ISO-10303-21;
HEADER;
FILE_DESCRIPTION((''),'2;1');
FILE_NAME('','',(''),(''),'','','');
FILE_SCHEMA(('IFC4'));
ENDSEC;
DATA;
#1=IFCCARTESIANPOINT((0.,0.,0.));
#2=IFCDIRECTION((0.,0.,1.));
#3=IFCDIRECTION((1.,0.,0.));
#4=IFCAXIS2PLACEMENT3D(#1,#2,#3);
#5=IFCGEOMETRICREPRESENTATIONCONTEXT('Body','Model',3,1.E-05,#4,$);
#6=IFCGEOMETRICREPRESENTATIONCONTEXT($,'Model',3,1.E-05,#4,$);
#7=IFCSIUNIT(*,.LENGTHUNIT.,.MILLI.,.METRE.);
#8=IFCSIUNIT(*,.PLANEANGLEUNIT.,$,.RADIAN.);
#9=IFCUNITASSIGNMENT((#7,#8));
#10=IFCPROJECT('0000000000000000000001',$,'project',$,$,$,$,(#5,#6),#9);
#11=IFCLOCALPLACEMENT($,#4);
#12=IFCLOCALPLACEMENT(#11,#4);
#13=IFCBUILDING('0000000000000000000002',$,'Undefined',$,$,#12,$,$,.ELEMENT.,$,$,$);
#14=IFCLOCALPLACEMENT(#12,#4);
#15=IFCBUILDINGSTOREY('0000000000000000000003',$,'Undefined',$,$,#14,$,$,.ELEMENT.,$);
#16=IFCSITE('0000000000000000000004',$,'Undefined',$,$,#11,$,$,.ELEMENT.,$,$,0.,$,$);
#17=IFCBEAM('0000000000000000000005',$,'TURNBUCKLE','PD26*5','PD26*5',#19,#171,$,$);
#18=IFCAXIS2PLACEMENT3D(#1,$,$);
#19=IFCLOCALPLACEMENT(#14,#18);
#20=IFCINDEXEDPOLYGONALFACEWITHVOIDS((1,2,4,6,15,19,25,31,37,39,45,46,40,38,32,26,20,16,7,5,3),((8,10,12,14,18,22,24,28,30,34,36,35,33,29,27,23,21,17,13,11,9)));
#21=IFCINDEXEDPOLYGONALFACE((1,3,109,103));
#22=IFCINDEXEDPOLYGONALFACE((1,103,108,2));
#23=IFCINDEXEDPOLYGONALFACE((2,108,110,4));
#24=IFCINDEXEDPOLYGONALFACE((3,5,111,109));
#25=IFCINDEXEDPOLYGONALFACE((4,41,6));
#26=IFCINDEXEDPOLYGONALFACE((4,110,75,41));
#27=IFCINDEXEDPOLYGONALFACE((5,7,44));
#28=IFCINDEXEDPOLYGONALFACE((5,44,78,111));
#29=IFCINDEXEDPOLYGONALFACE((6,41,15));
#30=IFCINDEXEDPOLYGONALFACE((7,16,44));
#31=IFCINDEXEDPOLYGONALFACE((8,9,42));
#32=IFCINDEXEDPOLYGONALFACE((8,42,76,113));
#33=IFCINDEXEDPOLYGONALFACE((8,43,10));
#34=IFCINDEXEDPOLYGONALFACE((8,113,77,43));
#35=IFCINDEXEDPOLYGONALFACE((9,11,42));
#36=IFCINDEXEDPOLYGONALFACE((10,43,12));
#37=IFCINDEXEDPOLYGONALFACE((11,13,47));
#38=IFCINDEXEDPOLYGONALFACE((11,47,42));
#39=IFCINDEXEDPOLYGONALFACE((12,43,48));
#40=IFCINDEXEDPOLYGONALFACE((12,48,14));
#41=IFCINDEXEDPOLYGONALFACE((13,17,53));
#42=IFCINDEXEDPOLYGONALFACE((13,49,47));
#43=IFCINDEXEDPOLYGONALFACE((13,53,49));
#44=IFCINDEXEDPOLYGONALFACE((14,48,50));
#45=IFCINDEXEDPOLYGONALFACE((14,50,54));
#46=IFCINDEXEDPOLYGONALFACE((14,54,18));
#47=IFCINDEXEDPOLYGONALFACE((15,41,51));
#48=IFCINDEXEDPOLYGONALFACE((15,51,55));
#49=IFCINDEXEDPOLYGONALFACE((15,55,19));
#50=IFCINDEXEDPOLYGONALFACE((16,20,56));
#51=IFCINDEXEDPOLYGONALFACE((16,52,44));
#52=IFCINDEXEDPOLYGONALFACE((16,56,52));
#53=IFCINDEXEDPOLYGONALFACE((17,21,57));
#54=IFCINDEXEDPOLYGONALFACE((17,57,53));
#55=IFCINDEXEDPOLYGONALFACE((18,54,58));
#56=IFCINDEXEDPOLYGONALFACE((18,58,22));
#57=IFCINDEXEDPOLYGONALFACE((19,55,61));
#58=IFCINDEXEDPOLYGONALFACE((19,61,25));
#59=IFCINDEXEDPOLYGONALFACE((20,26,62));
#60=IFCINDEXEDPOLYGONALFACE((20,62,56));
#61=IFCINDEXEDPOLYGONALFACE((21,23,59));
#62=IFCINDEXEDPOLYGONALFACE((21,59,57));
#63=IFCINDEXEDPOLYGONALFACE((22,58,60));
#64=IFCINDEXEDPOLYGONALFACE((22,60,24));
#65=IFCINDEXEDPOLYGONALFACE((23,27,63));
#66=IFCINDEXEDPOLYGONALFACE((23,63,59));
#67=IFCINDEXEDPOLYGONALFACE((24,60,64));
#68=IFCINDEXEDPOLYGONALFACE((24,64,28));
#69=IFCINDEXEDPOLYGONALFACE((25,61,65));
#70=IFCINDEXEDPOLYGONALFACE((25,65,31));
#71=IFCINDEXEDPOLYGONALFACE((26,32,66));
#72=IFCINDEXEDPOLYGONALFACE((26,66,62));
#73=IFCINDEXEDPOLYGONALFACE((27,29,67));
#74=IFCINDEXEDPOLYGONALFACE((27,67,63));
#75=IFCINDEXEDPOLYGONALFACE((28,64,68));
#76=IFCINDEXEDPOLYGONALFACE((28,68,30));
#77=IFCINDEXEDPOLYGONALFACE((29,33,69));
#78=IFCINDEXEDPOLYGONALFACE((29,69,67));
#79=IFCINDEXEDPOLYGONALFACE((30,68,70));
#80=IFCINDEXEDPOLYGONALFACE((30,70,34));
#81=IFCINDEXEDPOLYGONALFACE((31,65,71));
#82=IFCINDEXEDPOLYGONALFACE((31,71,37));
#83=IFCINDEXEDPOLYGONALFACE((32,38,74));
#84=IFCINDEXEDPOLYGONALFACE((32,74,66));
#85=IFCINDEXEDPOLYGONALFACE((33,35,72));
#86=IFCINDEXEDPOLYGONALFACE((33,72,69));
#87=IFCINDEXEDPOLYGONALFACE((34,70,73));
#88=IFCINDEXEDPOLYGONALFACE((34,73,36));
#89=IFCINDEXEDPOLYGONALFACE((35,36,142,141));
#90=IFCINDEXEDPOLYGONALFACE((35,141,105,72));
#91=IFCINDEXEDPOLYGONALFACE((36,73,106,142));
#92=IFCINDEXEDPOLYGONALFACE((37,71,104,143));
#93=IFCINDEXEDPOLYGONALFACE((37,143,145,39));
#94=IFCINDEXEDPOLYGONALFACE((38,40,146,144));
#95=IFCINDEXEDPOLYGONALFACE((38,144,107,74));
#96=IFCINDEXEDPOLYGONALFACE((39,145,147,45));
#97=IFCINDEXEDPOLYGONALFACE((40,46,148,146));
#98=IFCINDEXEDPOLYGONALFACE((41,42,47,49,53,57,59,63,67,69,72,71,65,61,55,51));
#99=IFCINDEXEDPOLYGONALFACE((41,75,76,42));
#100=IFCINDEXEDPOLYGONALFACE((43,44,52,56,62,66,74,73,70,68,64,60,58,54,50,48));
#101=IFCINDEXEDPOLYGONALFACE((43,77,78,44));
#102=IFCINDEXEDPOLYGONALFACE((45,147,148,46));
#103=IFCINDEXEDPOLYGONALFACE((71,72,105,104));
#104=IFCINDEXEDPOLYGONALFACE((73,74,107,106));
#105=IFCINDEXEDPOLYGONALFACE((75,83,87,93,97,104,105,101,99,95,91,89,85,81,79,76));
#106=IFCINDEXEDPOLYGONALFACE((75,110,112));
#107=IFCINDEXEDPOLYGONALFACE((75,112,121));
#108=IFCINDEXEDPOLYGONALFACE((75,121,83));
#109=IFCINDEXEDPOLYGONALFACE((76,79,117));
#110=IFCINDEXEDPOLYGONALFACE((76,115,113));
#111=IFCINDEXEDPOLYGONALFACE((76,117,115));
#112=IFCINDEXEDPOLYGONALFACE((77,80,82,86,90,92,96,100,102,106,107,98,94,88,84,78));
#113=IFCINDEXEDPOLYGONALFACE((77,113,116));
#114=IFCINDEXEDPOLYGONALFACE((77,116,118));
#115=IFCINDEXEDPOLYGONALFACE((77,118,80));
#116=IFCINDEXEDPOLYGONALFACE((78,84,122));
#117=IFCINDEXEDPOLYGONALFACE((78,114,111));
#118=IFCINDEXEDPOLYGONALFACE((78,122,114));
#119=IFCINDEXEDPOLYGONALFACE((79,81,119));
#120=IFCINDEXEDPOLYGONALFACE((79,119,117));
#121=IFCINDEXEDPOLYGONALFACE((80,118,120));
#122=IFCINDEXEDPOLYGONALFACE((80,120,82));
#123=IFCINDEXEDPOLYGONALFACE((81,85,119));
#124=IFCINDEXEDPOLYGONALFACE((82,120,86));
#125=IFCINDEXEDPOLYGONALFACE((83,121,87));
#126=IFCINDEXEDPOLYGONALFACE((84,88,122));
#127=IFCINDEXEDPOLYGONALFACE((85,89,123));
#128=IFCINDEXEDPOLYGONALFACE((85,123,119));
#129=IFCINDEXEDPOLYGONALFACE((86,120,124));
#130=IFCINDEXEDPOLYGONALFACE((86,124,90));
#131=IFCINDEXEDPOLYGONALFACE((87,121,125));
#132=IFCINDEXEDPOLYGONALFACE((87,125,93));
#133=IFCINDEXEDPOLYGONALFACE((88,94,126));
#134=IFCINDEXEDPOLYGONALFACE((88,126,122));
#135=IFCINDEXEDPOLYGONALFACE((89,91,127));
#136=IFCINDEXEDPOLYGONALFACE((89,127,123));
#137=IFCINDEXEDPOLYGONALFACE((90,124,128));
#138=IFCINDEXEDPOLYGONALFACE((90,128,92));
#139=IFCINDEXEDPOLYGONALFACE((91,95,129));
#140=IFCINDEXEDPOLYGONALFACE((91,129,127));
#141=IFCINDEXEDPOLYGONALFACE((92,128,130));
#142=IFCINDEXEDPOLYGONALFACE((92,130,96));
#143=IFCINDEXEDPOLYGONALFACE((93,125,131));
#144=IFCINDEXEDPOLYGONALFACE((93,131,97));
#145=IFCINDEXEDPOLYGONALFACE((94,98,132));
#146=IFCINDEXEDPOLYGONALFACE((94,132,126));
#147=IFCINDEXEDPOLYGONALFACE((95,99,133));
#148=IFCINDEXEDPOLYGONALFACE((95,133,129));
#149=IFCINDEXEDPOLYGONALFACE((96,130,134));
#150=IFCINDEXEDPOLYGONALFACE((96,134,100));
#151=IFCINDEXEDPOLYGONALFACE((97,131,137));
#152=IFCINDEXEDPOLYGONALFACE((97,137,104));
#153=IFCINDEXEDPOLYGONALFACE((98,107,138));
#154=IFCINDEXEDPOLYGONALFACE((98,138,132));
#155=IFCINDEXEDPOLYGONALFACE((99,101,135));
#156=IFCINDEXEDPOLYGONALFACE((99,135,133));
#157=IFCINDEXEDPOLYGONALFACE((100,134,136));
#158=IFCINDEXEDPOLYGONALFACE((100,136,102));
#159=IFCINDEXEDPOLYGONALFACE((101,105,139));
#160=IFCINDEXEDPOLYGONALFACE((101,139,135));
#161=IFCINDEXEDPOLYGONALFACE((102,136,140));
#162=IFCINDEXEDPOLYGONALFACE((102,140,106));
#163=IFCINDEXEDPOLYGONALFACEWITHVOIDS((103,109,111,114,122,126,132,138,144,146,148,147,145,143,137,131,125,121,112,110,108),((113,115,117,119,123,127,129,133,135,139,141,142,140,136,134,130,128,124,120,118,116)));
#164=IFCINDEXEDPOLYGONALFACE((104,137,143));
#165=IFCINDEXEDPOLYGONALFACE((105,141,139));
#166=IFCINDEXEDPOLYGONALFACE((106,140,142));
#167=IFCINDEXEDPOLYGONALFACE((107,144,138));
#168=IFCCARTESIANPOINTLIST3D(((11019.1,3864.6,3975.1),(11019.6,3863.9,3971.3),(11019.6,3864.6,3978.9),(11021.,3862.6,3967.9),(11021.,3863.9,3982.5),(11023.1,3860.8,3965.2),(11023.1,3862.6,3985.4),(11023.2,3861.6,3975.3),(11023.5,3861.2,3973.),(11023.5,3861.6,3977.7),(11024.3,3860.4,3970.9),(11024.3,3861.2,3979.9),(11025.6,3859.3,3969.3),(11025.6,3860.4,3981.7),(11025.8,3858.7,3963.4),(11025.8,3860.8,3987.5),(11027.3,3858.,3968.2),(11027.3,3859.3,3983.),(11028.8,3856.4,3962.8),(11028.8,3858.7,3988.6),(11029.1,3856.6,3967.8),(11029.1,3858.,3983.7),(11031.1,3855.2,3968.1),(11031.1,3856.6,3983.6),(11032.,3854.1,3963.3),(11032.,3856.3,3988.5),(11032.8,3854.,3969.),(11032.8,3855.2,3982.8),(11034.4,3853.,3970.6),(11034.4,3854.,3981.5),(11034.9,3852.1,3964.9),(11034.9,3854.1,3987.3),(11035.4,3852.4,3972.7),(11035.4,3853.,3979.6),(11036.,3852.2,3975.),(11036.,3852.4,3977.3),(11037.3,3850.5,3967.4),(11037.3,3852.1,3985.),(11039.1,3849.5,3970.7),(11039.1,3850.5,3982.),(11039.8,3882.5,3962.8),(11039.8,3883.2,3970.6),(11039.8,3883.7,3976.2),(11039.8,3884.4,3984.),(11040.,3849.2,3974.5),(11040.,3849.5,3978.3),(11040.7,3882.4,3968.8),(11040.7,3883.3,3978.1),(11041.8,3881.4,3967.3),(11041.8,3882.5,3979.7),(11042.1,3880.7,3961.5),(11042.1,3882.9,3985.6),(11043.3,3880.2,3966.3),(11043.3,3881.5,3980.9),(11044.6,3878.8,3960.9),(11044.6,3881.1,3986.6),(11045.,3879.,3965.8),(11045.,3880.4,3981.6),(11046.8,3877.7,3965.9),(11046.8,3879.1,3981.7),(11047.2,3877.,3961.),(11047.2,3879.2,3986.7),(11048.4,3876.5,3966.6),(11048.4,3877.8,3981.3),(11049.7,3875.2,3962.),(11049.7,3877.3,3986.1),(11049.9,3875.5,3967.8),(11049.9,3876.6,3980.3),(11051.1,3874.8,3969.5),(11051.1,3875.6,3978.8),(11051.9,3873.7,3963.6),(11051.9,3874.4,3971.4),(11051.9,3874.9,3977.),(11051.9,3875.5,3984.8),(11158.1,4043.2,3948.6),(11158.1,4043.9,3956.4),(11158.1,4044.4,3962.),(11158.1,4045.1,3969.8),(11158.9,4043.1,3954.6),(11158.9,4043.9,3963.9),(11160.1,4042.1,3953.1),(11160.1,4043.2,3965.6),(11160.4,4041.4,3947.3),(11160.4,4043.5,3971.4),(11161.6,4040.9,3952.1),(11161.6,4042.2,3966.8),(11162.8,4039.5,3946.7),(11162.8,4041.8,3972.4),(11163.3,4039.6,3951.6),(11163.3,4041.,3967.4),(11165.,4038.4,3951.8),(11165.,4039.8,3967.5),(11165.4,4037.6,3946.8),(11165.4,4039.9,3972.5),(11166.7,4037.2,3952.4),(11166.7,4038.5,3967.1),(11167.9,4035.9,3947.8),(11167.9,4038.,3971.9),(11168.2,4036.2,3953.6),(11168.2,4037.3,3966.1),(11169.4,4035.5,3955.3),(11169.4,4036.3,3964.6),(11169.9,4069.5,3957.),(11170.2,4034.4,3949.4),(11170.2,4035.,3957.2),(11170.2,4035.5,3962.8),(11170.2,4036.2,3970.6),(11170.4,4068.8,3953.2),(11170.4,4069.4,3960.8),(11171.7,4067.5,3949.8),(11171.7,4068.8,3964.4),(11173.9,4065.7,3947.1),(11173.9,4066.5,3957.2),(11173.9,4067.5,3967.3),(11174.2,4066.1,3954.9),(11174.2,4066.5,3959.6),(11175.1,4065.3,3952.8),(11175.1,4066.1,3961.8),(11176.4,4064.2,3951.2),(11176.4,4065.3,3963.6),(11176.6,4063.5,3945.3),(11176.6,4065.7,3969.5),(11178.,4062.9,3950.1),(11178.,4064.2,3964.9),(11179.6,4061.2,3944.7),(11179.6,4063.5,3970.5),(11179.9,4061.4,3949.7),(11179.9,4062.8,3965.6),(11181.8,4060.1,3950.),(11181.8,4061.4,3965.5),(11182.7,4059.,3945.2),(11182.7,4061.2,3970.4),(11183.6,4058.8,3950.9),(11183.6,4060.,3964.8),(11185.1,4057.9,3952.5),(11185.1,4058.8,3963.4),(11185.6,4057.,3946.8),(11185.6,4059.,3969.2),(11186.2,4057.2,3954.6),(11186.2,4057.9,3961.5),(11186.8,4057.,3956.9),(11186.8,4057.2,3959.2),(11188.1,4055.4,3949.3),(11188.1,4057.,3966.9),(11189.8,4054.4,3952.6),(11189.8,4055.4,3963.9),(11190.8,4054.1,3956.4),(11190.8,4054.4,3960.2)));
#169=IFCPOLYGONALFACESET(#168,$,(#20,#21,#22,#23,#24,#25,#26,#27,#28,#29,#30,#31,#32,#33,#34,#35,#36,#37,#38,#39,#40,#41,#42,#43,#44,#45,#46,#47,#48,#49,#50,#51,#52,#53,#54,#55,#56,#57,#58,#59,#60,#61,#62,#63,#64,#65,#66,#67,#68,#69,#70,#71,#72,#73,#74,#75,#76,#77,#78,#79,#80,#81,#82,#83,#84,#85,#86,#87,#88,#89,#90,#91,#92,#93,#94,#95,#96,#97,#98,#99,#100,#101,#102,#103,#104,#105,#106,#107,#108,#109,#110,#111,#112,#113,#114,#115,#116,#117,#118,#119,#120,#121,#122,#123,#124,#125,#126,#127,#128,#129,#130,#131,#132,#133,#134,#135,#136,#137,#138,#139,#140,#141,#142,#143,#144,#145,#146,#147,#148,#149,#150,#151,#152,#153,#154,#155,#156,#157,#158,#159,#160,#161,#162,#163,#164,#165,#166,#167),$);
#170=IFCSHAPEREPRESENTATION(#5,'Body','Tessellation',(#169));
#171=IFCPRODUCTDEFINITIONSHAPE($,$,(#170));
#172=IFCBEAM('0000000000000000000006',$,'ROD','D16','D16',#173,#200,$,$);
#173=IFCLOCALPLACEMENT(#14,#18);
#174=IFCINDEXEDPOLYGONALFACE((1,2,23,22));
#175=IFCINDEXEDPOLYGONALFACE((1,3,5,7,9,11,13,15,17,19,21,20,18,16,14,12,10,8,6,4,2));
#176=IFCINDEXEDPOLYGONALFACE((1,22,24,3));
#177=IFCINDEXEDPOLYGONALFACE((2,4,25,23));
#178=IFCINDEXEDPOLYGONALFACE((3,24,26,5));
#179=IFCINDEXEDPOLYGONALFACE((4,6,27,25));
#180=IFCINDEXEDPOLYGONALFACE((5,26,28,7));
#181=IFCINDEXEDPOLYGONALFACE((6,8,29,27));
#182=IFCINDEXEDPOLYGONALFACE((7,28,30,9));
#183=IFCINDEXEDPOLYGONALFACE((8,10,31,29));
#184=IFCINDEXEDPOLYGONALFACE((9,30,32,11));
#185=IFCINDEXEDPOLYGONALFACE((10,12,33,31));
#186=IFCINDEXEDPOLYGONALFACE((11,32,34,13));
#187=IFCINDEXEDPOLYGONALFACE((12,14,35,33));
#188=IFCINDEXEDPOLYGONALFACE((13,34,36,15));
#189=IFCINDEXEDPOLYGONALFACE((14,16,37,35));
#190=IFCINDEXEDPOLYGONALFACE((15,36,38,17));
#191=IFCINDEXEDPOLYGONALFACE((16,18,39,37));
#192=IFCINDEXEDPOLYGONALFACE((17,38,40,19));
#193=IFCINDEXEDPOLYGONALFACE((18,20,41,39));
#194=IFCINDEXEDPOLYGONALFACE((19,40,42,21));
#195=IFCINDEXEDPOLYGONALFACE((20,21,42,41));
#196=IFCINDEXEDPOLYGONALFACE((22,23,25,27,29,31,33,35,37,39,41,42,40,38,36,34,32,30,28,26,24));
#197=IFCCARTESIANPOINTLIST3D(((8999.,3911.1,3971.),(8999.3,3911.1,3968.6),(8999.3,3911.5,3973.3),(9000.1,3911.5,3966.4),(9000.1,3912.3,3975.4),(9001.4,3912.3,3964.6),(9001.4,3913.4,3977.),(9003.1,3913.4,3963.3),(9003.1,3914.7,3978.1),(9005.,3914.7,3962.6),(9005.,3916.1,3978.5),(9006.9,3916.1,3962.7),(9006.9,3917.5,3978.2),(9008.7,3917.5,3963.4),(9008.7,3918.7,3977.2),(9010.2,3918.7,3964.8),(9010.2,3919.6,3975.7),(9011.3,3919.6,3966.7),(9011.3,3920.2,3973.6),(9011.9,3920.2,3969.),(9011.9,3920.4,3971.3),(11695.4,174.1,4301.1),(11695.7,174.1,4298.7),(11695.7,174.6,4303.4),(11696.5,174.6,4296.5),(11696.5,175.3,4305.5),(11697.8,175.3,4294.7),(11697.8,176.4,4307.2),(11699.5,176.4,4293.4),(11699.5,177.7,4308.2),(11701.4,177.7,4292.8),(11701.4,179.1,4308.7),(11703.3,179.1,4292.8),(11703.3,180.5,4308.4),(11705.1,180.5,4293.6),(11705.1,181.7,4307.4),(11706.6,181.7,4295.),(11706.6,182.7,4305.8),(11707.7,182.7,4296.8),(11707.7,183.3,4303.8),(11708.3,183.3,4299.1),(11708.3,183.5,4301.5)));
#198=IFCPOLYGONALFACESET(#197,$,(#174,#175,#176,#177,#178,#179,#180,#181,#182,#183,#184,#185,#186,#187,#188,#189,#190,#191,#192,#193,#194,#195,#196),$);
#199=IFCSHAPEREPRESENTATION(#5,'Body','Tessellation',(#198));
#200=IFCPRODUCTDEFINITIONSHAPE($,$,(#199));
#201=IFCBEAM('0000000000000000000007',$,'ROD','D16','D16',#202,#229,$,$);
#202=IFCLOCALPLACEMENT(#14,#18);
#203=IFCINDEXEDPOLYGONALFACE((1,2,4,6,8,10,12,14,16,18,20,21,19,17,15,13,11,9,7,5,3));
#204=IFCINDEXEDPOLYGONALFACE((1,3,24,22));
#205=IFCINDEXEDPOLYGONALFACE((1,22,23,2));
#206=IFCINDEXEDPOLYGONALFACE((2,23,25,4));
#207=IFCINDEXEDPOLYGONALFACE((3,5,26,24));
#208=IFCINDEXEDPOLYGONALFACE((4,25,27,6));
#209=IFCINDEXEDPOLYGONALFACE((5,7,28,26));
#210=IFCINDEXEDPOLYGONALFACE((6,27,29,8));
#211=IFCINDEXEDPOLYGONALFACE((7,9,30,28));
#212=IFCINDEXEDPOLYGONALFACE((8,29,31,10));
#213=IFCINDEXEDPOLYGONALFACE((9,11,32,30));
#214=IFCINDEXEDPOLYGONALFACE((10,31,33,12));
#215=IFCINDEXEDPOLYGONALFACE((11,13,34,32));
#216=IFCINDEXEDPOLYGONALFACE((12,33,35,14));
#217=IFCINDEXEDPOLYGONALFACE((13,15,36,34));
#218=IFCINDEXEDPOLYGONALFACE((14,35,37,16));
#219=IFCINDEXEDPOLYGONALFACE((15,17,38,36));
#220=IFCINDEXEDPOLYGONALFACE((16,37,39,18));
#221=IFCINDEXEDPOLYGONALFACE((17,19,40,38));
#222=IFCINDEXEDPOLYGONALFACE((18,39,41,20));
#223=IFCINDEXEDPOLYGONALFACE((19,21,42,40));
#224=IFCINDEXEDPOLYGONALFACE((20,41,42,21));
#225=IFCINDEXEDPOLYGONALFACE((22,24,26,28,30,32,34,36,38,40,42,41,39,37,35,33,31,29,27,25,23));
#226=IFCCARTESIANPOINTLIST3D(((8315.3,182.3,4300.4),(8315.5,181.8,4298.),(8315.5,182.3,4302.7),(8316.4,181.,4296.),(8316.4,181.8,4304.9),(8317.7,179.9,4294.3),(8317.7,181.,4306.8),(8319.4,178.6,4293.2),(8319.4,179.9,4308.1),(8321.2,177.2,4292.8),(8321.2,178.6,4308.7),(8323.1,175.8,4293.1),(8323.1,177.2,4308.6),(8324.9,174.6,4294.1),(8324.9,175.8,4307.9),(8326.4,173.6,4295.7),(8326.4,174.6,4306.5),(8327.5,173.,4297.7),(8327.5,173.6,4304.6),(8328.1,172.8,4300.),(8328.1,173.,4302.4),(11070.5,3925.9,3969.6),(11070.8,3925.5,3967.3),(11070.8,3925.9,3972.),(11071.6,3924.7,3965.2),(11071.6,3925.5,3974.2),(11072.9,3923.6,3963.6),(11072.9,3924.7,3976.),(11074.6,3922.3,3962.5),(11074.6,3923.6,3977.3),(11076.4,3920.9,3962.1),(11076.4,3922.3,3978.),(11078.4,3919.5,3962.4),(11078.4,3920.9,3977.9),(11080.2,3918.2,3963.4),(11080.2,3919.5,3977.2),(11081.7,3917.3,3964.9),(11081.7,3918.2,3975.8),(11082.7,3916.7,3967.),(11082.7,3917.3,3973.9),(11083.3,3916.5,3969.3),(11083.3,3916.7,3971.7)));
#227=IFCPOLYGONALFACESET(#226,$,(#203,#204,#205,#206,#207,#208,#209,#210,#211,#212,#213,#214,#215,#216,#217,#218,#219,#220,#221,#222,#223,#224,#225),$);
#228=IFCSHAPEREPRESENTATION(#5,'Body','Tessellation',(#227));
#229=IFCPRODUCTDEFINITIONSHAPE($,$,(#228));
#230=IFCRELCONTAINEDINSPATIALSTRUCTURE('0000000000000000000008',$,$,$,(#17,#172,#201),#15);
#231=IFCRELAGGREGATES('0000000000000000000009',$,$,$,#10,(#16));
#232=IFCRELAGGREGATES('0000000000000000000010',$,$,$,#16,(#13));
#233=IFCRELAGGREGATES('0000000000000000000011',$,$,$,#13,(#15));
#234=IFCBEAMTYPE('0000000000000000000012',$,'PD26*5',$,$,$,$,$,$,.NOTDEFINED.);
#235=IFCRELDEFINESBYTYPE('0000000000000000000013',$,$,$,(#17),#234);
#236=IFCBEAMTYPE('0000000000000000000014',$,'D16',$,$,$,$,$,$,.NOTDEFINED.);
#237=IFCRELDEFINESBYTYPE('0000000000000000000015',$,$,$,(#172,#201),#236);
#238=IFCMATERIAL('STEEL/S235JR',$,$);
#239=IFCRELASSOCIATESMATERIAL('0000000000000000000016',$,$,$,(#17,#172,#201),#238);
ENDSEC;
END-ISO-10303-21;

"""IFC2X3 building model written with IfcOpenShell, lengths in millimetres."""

from ifc_helpers import new_model, si_unit, frame, origin_with_axes, origin_2d_with_axis, place, context, project, spatial, rectangle, circle, hollow_circle, extrude, material, type_object, element, save


model = new_model("IFC2X3")

# Units and contexts
model_context_1 = context("Model", 3, precision=1e-05, world=origin_with_axes(), identifier="Body")
model_context_2 = context("Model", 3, precision=1e-05, world=origin_with_axes())
ifc_project = project(units=[si_unit("LENGTHUNIT", "METRE", prefix="MILLI"), si_unit("PLANEANGLEUNIT", "RADIAN")], contexts=[model_context_1, model_context_2])

# Site, building, storey
site_placement = place(None, origin_with_axes())
site = spatial("IfcSite", under=ifc_project, at=site_placement, Name="Undefined", CompositionType="ELEMENT", RefElevation=0.0)
building_placement = place(site_placement, origin_with_axes())
building = spatial("IfcBuilding", under=site, at=building_placement, Name="Undefined", CompositionType="ELEMENT")
storey_placement = place(building_placement, origin_with_axes())
storey = spatial("IfcBuildingStorey", under=building, at=storey_placement, Name="Undefined", CompositionType="ELEMENT")

# Shared definitions
ifc_material = material(Name="STEEL/S235JR")

# Beam, opening
beam_type_1 = type_object("IfcBeamType", Name="PD26*5", PredefinedType="NOTDEFINED")
beam_1_placement = place(storey_placement, frame((11180.4, 4061.8, 3957.6), z_axis=(0.0, 0.087999, 0.996121), x_axis=(-0.591248, -0.803361, 0.070971)))
beam_1 = element("IfcBeam", 1, at=beam_1_placement, inside=storey, type_object=beam_type_1, material=ifc_material, Name="TURNBUCKLE", Description="PD26*5", ObjectType="PD26*5", context=model_context_1, shape_type="SweptSolid", body=[
    extrude(hollow_circle(Radius=13.0, WallThickness=5.0, at=origin_2d_with_axis()), frame((255.0, 0.0, 0.0), z_axis=(-1.0, 0.0, 0.0), x_axis=(0.0, -1.0, 0.0)), (0.0, 0.0, 1.0), 255.0),
])
opening_1_placement = place(storey_placement, frame((11180.4, 4061.8, 3957.6), z_axis=(0.0, 0.087999, 0.996121), x_axis=(-0.591248, -0.803361, 0.070971)))
element("IfcOpeningElement", 2, at=opening_1_placement, cuts=beam_1, ObjectType="Recess", context=model_context_1, shape_type="SweptSolid", body=[
    extrude(rectangle(XDim=15.0, YDim=52.0, at=origin_2d_with_axis()), frame((227.5, 0.0, 0.0), z_axis=(-1.0, 0.0, 0.0), x_axis=(0.0, -1.0, 0.0)), (0.0, 0.0, 1.0), 200.0),
])

# Beams
beam_type_2 = type_object("IfcBeamType", Name="D16", PredefinedType="NOTDEFINED")
beam_2_placement = place(storey_placement, frame((9005.5, 3915.7, 3970.5), z_axis=(0.0, 0.087999, 0.996121), x_axis=(0.583639, -0.808863, 0.071457)))
element("IfcBeam", 3, at=beam_2_placement, inside=storey, type_object=beam_type_2, material=ifc_material, Name="ROD", Description="D16", ObjectType="D16", context=model_context_1, shape_type="SweptSolid", body=[
    extrude(circle(Radius=8.0, at=origin_2d_with_axis()), frame((4620.0, 0.0, 0.0), z_axis=(-1.0, 0.0, 0.0), x_axis=(0.0, -1.0, 0.0)), (0.0, 0.0, 1.0), 4620.0),
])
beam_3_placement = place(storey_placement, frame((11076.9, 3921.2, 3970.1), z_axis=(0.0, 0.087999, 0.996121), x_axis=(-0.591248, -0.803361, 0.070971)))
element("IfcBeam", 4, at=beam_3_placement, inside=storey, type_object=beam_type_2, material=ifc_material, Name="ROD", Description="D16", ObjectType="D16", context=model_context_1, shape_type="SweptSolid", body=[
    extrude(circle(Radius=8.0, at=origin_2d_with_axis()), frame((4660.0, 0.0, 0.0), z_axis=(-1.0, 0.0, 0.0), x_axis=(0.0, -1.0, 0.0)), (0.0, 0.0, 1.0), 4660.0),
])

save(model, "model.ifc")
